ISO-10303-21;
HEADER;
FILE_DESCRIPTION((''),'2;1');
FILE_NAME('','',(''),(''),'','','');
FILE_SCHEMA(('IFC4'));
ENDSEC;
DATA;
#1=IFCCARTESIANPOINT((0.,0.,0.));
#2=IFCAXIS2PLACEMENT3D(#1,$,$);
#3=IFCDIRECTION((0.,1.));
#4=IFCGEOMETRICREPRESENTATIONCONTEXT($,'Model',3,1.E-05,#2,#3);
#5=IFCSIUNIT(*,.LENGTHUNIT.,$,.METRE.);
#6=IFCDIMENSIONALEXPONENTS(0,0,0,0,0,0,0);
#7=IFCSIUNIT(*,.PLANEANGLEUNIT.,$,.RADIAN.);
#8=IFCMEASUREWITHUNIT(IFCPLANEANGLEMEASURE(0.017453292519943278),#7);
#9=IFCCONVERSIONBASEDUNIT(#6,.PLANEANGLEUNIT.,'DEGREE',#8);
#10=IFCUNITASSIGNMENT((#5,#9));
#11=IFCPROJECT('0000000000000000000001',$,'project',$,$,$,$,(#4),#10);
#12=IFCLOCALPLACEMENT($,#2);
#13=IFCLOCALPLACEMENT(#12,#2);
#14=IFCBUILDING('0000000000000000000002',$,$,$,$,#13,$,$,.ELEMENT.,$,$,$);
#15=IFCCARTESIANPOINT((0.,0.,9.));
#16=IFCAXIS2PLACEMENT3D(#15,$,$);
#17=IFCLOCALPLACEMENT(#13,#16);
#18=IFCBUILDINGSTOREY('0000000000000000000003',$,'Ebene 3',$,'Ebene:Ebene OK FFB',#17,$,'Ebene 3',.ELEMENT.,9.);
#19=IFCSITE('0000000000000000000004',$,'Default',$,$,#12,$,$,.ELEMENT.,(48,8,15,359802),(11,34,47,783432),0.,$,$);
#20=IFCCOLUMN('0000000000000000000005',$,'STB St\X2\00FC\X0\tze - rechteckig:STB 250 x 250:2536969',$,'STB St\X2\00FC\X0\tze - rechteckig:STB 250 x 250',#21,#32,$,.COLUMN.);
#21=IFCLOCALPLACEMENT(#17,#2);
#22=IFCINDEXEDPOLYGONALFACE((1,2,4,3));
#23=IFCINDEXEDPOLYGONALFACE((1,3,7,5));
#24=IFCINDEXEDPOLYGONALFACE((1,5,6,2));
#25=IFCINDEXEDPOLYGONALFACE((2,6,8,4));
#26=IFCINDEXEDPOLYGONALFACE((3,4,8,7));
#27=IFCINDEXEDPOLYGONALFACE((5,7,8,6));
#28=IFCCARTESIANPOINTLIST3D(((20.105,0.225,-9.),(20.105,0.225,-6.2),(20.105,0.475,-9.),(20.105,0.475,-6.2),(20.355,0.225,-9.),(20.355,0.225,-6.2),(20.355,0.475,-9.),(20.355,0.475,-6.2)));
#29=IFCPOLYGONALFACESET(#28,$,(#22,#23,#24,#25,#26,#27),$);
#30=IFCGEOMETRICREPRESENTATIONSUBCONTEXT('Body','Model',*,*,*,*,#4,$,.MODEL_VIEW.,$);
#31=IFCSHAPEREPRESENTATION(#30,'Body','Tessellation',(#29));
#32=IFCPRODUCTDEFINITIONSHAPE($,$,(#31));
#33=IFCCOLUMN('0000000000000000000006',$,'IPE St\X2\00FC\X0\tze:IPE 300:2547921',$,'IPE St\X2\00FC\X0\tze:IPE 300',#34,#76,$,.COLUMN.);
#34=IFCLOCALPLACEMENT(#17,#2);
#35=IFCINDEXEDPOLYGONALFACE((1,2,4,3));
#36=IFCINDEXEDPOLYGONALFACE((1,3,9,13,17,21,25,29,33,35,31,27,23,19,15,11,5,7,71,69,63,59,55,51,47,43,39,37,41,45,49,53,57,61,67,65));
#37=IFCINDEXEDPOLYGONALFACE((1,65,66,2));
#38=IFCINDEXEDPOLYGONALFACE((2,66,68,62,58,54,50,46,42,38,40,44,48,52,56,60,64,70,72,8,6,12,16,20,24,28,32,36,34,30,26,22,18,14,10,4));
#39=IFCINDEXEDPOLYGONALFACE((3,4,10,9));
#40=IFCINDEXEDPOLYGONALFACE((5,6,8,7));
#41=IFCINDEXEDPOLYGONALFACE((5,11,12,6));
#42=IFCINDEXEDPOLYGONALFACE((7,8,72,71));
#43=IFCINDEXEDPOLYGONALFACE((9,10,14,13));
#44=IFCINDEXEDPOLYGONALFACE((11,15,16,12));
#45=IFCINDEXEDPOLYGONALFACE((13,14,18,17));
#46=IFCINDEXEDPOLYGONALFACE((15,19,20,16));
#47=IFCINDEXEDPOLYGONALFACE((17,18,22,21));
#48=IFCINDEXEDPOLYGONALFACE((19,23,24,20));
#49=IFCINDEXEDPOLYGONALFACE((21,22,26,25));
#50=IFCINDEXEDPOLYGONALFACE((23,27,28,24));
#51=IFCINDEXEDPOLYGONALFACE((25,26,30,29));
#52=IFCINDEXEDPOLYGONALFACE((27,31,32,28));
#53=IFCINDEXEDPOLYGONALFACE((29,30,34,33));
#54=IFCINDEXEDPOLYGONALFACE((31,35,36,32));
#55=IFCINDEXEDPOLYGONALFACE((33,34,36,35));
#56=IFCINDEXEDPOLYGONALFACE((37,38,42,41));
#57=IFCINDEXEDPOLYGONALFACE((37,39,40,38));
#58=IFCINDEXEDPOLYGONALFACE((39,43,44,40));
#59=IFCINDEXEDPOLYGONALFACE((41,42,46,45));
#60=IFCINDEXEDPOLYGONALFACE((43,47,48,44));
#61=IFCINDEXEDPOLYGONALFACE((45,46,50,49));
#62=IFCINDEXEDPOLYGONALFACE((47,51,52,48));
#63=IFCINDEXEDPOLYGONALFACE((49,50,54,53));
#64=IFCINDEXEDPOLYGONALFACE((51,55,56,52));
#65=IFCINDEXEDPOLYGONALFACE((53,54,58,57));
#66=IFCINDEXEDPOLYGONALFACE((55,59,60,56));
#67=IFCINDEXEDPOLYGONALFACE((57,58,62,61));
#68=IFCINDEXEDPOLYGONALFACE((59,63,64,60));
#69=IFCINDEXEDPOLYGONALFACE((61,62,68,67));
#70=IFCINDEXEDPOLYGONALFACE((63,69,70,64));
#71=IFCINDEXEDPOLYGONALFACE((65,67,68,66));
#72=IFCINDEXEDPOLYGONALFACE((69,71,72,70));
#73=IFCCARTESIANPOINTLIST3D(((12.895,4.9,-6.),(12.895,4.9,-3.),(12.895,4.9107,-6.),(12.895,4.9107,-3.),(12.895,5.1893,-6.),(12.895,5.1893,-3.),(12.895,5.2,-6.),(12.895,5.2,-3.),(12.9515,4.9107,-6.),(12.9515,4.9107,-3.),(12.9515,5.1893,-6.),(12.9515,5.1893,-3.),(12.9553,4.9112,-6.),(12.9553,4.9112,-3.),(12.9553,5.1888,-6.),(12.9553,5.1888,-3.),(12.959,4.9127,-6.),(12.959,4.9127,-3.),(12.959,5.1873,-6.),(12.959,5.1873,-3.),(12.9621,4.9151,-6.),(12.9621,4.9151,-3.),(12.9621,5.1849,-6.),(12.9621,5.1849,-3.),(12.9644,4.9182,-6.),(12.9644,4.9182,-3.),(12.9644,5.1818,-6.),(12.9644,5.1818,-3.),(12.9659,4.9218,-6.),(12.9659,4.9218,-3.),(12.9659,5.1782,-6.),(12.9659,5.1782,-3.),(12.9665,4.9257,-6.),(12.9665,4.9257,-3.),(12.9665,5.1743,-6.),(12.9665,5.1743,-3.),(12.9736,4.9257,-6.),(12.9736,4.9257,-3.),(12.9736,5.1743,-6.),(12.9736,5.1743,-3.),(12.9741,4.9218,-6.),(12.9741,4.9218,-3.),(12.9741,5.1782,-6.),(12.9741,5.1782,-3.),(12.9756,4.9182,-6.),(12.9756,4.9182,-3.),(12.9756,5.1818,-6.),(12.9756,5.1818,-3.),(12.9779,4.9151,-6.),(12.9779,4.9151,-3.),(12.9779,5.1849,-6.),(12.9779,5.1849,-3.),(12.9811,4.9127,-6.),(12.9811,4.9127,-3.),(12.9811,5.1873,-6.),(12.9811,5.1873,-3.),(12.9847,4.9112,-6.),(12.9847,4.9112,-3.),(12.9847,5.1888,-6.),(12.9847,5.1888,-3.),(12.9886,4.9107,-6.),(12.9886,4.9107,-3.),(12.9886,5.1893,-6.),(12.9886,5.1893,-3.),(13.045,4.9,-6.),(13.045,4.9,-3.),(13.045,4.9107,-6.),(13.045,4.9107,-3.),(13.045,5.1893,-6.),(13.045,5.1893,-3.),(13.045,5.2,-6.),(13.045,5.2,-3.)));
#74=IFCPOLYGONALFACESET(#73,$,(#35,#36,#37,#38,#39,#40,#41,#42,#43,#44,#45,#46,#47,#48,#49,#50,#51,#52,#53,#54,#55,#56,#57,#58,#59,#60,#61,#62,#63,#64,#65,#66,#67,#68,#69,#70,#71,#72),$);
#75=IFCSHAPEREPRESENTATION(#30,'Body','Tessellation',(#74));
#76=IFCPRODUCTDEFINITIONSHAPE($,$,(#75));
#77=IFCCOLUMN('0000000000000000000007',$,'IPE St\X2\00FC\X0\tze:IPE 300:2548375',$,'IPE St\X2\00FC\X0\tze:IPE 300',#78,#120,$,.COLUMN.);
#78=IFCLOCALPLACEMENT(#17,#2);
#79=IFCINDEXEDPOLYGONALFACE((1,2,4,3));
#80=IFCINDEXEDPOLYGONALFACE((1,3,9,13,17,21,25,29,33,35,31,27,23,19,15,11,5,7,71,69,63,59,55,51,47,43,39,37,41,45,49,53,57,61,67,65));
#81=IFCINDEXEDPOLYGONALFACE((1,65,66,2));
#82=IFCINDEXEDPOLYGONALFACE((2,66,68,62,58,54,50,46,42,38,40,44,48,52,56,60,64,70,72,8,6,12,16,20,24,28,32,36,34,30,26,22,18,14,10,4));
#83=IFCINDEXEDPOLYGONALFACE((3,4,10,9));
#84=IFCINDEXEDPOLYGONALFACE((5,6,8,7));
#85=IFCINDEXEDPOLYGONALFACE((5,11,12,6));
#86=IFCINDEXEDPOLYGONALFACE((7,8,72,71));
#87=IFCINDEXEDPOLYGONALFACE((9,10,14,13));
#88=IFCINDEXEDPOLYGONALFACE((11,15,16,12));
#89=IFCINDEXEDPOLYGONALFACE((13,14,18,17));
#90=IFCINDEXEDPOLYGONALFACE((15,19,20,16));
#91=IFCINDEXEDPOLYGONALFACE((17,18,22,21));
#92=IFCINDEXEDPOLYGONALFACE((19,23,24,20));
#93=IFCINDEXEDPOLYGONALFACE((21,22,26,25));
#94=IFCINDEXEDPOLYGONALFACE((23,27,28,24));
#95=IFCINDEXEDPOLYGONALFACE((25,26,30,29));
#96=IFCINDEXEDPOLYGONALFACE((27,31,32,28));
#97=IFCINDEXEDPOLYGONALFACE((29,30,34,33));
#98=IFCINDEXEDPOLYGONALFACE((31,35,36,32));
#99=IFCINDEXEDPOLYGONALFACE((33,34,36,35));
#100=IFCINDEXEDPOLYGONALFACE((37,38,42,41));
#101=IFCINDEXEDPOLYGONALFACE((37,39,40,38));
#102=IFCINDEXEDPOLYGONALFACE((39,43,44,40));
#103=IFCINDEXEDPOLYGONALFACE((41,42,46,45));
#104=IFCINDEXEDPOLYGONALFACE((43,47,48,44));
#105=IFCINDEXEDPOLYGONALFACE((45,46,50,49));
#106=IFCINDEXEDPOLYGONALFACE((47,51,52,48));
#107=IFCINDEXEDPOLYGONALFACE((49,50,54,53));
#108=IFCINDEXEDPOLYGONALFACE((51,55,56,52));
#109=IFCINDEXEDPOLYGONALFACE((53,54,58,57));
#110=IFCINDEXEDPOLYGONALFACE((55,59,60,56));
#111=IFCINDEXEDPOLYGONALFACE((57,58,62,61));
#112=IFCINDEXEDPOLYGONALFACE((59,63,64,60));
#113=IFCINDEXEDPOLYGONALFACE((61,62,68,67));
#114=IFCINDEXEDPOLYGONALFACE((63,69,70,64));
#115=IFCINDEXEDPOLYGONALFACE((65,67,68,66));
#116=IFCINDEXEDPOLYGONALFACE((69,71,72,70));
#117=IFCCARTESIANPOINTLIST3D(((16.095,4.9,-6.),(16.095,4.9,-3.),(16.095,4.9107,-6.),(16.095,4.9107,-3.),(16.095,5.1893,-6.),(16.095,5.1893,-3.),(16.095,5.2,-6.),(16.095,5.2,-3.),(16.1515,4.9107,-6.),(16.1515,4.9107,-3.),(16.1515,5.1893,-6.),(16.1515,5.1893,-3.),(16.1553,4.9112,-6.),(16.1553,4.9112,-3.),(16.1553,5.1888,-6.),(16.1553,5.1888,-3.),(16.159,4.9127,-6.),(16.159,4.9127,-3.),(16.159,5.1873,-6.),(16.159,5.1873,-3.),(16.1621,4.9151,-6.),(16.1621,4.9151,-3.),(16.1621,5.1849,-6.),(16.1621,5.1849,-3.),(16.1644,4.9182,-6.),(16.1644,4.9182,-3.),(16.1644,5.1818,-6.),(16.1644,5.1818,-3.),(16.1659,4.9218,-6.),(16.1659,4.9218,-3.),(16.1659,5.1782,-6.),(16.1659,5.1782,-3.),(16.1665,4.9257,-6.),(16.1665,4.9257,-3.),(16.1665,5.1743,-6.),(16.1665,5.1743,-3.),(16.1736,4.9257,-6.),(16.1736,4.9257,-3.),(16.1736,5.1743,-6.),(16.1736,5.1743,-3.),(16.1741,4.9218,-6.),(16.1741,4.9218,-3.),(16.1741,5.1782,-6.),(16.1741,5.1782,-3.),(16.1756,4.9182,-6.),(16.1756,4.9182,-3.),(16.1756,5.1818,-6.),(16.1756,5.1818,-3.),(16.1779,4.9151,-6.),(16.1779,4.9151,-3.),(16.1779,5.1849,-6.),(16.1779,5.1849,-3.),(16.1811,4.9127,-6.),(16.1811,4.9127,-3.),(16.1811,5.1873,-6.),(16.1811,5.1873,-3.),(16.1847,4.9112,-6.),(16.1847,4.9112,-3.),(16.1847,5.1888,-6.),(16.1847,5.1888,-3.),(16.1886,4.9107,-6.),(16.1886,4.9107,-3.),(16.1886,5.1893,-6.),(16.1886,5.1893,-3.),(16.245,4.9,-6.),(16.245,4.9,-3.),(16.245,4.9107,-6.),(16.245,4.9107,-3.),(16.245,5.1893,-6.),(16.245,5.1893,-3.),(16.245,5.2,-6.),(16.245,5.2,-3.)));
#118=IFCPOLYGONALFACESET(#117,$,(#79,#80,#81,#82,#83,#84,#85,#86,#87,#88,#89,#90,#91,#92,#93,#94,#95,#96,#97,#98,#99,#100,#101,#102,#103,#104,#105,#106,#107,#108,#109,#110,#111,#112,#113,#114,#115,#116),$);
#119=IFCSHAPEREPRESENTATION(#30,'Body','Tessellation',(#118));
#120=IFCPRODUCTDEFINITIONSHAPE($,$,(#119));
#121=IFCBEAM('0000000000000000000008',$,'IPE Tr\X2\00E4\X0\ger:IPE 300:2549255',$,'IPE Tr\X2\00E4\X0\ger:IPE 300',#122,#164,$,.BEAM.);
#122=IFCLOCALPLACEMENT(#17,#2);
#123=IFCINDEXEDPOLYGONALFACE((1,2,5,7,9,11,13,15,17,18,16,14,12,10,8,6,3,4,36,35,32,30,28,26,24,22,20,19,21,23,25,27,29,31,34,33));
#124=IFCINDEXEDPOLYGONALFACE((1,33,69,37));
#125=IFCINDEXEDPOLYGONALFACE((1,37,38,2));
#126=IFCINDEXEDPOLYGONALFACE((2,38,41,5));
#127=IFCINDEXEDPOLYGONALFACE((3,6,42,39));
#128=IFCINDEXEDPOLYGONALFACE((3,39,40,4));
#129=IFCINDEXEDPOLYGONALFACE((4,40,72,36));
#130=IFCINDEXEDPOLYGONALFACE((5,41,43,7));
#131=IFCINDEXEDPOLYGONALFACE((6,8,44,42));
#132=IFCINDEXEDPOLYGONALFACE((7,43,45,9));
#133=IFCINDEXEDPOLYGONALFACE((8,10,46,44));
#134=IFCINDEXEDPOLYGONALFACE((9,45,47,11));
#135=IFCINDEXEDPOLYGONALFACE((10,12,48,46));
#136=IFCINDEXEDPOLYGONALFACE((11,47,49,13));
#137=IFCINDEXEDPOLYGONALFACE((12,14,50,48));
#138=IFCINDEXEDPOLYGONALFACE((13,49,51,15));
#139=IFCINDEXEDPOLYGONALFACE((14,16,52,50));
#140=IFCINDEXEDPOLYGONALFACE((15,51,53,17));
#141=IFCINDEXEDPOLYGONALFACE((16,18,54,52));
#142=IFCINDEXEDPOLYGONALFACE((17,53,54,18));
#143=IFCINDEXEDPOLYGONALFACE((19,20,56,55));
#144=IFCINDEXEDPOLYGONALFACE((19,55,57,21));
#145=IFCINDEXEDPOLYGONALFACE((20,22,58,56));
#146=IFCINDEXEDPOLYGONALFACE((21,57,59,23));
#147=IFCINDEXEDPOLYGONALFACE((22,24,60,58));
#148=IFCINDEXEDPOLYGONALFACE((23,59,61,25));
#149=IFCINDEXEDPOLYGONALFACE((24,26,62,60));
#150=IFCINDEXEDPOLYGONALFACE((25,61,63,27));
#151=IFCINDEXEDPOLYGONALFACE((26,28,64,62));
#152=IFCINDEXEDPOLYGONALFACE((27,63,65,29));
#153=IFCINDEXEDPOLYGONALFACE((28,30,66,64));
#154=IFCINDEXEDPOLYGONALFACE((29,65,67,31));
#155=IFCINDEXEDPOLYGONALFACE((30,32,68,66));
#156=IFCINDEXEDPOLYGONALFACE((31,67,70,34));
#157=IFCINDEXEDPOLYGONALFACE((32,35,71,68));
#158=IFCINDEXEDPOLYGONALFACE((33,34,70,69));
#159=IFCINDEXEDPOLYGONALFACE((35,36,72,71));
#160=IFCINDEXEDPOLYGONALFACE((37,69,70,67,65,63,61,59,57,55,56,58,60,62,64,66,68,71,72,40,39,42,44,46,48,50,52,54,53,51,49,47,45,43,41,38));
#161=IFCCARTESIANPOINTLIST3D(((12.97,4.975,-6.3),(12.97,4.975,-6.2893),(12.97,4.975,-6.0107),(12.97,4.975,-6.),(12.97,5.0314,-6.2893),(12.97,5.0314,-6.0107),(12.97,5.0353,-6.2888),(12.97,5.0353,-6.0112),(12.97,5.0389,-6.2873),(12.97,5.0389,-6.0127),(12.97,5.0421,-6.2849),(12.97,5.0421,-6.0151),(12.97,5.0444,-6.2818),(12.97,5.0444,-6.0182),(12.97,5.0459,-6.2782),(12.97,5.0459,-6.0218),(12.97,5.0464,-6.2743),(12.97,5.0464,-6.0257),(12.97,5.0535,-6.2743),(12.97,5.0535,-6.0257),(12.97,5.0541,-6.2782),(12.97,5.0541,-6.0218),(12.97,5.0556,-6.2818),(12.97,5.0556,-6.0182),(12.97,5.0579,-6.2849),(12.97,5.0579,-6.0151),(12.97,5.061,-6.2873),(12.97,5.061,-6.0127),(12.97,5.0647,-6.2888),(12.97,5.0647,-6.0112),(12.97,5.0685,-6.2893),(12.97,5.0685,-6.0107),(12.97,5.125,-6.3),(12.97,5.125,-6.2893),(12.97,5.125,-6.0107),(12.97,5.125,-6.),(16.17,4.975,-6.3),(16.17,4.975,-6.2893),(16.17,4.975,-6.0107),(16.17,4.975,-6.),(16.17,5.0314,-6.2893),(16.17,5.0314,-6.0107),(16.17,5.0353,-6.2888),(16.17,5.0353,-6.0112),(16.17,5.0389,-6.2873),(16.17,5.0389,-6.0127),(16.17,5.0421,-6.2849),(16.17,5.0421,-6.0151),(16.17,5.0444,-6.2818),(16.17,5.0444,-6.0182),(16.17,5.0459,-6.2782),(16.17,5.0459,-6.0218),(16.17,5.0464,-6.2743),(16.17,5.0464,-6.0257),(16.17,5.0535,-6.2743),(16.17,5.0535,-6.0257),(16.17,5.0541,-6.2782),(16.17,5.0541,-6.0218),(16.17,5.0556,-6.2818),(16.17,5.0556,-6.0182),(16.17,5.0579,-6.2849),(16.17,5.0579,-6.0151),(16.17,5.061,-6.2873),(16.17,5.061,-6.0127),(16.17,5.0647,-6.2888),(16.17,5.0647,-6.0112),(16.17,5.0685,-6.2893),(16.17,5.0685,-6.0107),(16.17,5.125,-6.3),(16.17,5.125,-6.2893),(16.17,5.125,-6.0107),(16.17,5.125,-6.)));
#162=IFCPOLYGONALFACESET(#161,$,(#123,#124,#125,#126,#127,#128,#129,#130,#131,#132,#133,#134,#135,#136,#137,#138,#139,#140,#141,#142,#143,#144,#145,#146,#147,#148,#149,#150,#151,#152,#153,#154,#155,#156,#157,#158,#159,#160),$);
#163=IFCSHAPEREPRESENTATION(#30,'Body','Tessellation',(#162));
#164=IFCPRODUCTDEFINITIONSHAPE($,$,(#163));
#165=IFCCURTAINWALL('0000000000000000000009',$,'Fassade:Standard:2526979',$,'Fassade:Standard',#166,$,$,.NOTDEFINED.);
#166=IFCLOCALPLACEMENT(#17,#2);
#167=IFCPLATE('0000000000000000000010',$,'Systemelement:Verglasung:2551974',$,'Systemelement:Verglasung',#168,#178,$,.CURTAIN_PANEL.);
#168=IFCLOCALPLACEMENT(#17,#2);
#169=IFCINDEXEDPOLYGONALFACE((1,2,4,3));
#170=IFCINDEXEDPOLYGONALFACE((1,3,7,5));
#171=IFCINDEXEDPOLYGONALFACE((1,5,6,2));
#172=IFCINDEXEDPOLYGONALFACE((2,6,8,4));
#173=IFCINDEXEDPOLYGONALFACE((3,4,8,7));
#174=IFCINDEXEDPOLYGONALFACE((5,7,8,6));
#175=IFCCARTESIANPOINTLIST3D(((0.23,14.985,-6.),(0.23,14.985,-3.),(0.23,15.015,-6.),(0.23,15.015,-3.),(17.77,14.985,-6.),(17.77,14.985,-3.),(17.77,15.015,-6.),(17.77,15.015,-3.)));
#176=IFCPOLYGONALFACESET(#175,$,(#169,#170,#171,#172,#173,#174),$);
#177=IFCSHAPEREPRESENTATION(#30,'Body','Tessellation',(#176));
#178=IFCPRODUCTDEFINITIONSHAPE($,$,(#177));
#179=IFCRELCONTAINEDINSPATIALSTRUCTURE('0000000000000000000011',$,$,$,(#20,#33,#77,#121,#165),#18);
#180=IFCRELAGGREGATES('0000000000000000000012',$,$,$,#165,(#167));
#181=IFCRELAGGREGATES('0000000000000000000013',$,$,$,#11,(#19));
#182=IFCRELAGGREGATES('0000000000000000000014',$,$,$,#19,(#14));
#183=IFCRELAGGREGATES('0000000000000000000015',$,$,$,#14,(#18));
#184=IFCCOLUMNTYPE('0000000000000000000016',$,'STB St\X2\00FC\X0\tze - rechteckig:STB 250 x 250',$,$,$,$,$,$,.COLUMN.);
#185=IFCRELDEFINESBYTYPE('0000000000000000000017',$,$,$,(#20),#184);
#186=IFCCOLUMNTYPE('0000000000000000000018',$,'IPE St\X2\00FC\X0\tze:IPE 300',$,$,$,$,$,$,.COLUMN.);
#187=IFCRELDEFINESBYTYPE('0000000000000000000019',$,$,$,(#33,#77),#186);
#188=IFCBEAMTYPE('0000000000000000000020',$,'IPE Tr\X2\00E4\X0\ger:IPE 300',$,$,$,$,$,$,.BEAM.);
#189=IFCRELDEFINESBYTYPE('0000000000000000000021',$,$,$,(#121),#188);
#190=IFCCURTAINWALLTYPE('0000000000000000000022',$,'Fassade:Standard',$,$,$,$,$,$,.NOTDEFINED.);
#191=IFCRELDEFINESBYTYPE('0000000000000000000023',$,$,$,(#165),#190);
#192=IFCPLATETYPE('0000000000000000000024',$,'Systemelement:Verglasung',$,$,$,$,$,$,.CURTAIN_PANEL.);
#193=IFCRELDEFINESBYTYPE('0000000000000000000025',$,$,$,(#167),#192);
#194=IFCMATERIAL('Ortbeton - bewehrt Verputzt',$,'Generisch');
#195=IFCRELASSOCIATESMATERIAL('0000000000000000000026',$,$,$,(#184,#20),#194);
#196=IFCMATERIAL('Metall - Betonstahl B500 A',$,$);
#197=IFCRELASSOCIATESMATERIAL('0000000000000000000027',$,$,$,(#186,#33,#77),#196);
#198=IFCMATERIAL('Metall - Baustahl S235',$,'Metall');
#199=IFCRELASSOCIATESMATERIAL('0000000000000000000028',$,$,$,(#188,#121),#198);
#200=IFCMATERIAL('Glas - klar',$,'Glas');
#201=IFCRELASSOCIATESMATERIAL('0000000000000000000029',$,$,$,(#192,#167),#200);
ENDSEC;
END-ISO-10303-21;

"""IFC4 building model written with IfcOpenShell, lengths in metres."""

from ifc_helpers import new_model, entity, si_unit, converted_unit, direction, frame, origin, place, context, subcontext, project, spatial, line, arc, indexed_curve, outline, extrude, source, transform, mapped, material, type_object, type_shapes, element, aggregate, save


model = new_model("IFC4")

# Units and contexts
model_context = context("Model", 3, precision=1e-05, world=origin(), true_north=direction((0.0, 1.0)))
body_context = subcontext(model_context, "Body", "Model", "MODEL_VIEW")
ifc_project = project(units=[si_unit("LENGTHUNIT", "METRE"), converted_unit("PLANEANGLEUNIT", "DEGREE", entity("IfcPlaneAngleMeasure", 0.017453292519943278), si_unit("PLANEANGLEUNIT", "RADIAN"), dimensions=[0, 0, 0, 0, 0, 0, 0])], contexts=[model_context])

# Site, building, storey
site_placement = place(None, origin())
site = spatial("IfcSite", under=ifc_project, at=site_placement, Name="Default", CompositionType="ELEMENT", RefLatitude=(48, 8, 15, 359802), RefLongitude=(11, 34, 47, 783432), RefElevation=0.0)
building_placement = place(site_placement, origin())
building = spatial("IfcBuilding", under=site, at=building_placement, CompositionType="ELEMENT")
storey_placement = place(building_placement, frame((0.0, 0.0, 9.0)))
storey = spatial("IfcBuildingStorey", under=building, at=storey_placement, Name="Ebene 3", ObjectType="Ebene:Ebene OK FFB", LongName="Ebene 3", CompositionType="ELEMENT", Elevation=9.0)

# Columns
ifc_material_1 = material(Name="Ortbeton - bewehrt Verputzt", Category="Generisch")
column_type_1 = type_object("IfcColumnType", Name="STB Stütze - rechteckig:STB 250 x 250", PredefinedType="COLUMN", material=ifc_material_1)
shared_shape_1 = source(origin(), body_context, "Body", "SweptSolid", [
    extrude(outline(indexed_curve([(-0.125, -0.125), (0.125, -0.125), (0.125, 0.125), (-0.125, 0.125), (-0.125, -0.125)], self_intersect=False)), frame((20.23, 0.35, 0.0), z_axis=(0.0, 0.0, 1.0), x_axis=(-1.0, 0.0, 0.0)), (0.0, 0.0, 1.0), 2.8),
])
type_shapes(column_type_1, [shared_shape_1])
column_1_placement = place(storey_placement, frame((0.0, 0.0, -9.0)))
element("IfcColumn", 1, at=column_1_placement, inside=storey, type_object=column_type_1, material=ifc_material_1, Name="STB Stütze - rechteckig:STB 250 x 250:2536969", ObjectType="STB Stütze - rechteckig:STB 250 x 250", PredefinedType="COLUMN", context=body_context, shape_type="MappedRepresentation", body=[
    mapped(shared_shape_1, transform((0.0, 0.0, 0.0), scale=1.0)),
])
ifc_material_2 = material(Name="Metall - Betonstahl B500 A")
column_type_2 = type_object("IfcColumnType", Name="IPE Stütze:IPE 300", PredefinedType="COLUMN", material=ifc_material_2)
shared_shape_2 = source(origin(), body_context, "Body", "SweptSolid", [
    extrude(outline(indexed_curve([(-0.075, -0.15), (0.075, -0.15), (0.075, -0.1393), (0.0186, -0.1393), (0.0079, -0.1349), (0.0035, -0.1243), (0.0035, 0.1243), (0.0079, 0.1349), (0.0185, 0.1393), (0.075, 0.1393), (0.075, 0.15), (-0.075, 0.15), (-0.075, 0.1393), (-0.0186, 0.1393), (-0.0079, 0.1349), (-0.0035, 0.1243), (-0.0036, -0.1243), (-0.0079, -0.1349), (-0.0186, -0.1393), (-0.075, -0.1393)], segments=[line(1, 2, 3, 4), arc(4, 5, 6), line(6, 7), arc(7, 8, 9), line(9, 10, 11, 12, 13, 14), arc(14, 15, 16), line(16, 17), arc(17, 18, 19), line(19, 20, 1)], self_intersect=False)), frame((0.0, 0.0, 3.0), z_axis=(0.0, 0.0, 1.0), x_axis=(-1.0, 0.0, 0.0)), (0.0, 0.0, 1.0), 3.0),
])
type_shapes(column_type_2, [shared_shape_2])
for number, where, name in (
    (2, (12.97, 5.05, -9.0), "IPE Stütze:IPE 300:2547921"),
    (3, (16.17, 5.05, -9.0), "IPE Stütze:IPE 300:2548375"),
):
    element("IfcColumn", number, at=place(storey_placement, frame(where)), inside=storey, type_object=column_type_2, material=ifc_material_2, Name=name, ObjectType="IPE Stütze:IPE 300", PredefinedType="COLUMN", context=body_context, shape_type="MappedRepresentation", body=[
        mapped(shared_shape_2, transform((0.0, 0.0, 0.0), scale=1.0)),
    ])

# Beam
ifc_material_3 = material(Name="Metall - Baustahl S235", Category="Metall")
beam_type = type_object("IfcBeamType", Name="IPE Träger:IPE 300", PredefinedType="BEAM", material=ifc_material_3)
shared_shape_3 = source(origin(), body_context, "Body", "SweptSolid", [
    extrude(outline(indexed_curve([(-0.15, -0.075), (-0.1393, -0.075), (-0.1393, -0.0186), (-0.1349, -0.0079), (-0.1243, -0.0036), (0.1243, -0.0036), (0.1349, -0.0079), (0.1393, -0.0186), (0.1393, -0.075), (0.15, -0.075), (0.15, 0.075), (0.1393, 0.075), (0.1393, 0.0186), (0.1349, 0.0079), (0.1243, 0.0036), (-0.1243, 0.0036), (-0.1349, 0.0079), (-0.1393, 0.0186), (-0.1393, 0.075), (-0.15, 0.075)], segments=[line(1, 2, 3), arc(3, 4, 5), line(5, 6), arc(6, 7, 8), line(8, 9, 10, 11, 12, 13), arc(13, 14, 15), line(15, 16), arc(16, 17, 18), line(18, 19, 20, 1)], self_intersect=False)), frame((12.97, 5.05, 2.85), z_axis=(1.0, 0.0, 0.0), x_axis=(0.0, 0.0, -1.0)), (0.0, 0.0, 1.0), 3.2),
])
type_shapes(beam_type, [shared_shape_3])
beam_placement = place(storey_placement, frame((0.0, 0.0, -9.0)))
element("IfcBeam", 4, at=beam_placement, inside=storey, type_object=beam_type, material=ifc_material_3, Name="IPE Träger:IPE 300:2549255", ObjectType="IPE Träger:IPE 300", PredefinedType="BEAM", context=body_context, shape_type="MappedRepresentation", body=[
    mapped(shared_shape_3, transform((0.0, 0.0, 0.0), scale=1.0)),
])

# Curtain wall, plate
curtain_wall_type = type_object("IfcCurtainWallType", Name="Fassade:Standard", PredefinedType="NOTDEFINED")
curtain_wall_placement = place(storey_placement, frame((0.0, 0.0, -9.0)))
curtain_wall = element("IfcCurtainWall", 5, at=curtain_wall_placement, inside=storey, type_object=curtain_wall_type, Name="Fassade:Standard:2526979", ObjectType="Fassade:Standard", PredefinedType="NOTDEFINED")
ifc_material_4 = material(Name="Glas - klar", Category="Glas")
plate_type = type_object("IfcPlateType", Name="Systemelement:Verglasung", PredefinedType="CURTAIN_PANEL", material=ifc_material_4)
shared_shape_4 = source(origin(), body_context, "Body", "SweptSolid", [
    extrude(outline(indexed_curve([(-0.015, -8.77), (0.015, -8.77), (0.015, 8.77), (-0.015, 8.77), (-0.015, -8.77)], self_intersect=False)), frame((0.0, 0.0, 0.0), z_axis=(0.0, 0.0, 1.0), x_axis=(0.0, 1.0, 0.0)), (0.0, 0.0, 1.0), 3.0),
])
type_shapes(plate_type, [shared_shape_4])
plate_placement = place(curtain_wall_placement, frame((9.0, 15.0, 3.0), z_axis=(0.0, 0.0, 1.0), x_axis=(-1.0, 0.0, 0.0)))
plate = element("IfcPlate", 6, at=plate_placement, type_object=plate_type, material=ifc_material_4, Name="Systemelement:Verglasung:2551974", ObjectType="Systemelement:Verglasung", PredefinedType="CURTAIN_PANEL", context=body_context, shape_type="MappedRepresentation", body=[
    mapped(shared_shape_4, transform((0.0, 0.0, 0.0), scale=1.0)),
])
aggregate(curtain_wall, [plate])

save(model, "model.ifc")
